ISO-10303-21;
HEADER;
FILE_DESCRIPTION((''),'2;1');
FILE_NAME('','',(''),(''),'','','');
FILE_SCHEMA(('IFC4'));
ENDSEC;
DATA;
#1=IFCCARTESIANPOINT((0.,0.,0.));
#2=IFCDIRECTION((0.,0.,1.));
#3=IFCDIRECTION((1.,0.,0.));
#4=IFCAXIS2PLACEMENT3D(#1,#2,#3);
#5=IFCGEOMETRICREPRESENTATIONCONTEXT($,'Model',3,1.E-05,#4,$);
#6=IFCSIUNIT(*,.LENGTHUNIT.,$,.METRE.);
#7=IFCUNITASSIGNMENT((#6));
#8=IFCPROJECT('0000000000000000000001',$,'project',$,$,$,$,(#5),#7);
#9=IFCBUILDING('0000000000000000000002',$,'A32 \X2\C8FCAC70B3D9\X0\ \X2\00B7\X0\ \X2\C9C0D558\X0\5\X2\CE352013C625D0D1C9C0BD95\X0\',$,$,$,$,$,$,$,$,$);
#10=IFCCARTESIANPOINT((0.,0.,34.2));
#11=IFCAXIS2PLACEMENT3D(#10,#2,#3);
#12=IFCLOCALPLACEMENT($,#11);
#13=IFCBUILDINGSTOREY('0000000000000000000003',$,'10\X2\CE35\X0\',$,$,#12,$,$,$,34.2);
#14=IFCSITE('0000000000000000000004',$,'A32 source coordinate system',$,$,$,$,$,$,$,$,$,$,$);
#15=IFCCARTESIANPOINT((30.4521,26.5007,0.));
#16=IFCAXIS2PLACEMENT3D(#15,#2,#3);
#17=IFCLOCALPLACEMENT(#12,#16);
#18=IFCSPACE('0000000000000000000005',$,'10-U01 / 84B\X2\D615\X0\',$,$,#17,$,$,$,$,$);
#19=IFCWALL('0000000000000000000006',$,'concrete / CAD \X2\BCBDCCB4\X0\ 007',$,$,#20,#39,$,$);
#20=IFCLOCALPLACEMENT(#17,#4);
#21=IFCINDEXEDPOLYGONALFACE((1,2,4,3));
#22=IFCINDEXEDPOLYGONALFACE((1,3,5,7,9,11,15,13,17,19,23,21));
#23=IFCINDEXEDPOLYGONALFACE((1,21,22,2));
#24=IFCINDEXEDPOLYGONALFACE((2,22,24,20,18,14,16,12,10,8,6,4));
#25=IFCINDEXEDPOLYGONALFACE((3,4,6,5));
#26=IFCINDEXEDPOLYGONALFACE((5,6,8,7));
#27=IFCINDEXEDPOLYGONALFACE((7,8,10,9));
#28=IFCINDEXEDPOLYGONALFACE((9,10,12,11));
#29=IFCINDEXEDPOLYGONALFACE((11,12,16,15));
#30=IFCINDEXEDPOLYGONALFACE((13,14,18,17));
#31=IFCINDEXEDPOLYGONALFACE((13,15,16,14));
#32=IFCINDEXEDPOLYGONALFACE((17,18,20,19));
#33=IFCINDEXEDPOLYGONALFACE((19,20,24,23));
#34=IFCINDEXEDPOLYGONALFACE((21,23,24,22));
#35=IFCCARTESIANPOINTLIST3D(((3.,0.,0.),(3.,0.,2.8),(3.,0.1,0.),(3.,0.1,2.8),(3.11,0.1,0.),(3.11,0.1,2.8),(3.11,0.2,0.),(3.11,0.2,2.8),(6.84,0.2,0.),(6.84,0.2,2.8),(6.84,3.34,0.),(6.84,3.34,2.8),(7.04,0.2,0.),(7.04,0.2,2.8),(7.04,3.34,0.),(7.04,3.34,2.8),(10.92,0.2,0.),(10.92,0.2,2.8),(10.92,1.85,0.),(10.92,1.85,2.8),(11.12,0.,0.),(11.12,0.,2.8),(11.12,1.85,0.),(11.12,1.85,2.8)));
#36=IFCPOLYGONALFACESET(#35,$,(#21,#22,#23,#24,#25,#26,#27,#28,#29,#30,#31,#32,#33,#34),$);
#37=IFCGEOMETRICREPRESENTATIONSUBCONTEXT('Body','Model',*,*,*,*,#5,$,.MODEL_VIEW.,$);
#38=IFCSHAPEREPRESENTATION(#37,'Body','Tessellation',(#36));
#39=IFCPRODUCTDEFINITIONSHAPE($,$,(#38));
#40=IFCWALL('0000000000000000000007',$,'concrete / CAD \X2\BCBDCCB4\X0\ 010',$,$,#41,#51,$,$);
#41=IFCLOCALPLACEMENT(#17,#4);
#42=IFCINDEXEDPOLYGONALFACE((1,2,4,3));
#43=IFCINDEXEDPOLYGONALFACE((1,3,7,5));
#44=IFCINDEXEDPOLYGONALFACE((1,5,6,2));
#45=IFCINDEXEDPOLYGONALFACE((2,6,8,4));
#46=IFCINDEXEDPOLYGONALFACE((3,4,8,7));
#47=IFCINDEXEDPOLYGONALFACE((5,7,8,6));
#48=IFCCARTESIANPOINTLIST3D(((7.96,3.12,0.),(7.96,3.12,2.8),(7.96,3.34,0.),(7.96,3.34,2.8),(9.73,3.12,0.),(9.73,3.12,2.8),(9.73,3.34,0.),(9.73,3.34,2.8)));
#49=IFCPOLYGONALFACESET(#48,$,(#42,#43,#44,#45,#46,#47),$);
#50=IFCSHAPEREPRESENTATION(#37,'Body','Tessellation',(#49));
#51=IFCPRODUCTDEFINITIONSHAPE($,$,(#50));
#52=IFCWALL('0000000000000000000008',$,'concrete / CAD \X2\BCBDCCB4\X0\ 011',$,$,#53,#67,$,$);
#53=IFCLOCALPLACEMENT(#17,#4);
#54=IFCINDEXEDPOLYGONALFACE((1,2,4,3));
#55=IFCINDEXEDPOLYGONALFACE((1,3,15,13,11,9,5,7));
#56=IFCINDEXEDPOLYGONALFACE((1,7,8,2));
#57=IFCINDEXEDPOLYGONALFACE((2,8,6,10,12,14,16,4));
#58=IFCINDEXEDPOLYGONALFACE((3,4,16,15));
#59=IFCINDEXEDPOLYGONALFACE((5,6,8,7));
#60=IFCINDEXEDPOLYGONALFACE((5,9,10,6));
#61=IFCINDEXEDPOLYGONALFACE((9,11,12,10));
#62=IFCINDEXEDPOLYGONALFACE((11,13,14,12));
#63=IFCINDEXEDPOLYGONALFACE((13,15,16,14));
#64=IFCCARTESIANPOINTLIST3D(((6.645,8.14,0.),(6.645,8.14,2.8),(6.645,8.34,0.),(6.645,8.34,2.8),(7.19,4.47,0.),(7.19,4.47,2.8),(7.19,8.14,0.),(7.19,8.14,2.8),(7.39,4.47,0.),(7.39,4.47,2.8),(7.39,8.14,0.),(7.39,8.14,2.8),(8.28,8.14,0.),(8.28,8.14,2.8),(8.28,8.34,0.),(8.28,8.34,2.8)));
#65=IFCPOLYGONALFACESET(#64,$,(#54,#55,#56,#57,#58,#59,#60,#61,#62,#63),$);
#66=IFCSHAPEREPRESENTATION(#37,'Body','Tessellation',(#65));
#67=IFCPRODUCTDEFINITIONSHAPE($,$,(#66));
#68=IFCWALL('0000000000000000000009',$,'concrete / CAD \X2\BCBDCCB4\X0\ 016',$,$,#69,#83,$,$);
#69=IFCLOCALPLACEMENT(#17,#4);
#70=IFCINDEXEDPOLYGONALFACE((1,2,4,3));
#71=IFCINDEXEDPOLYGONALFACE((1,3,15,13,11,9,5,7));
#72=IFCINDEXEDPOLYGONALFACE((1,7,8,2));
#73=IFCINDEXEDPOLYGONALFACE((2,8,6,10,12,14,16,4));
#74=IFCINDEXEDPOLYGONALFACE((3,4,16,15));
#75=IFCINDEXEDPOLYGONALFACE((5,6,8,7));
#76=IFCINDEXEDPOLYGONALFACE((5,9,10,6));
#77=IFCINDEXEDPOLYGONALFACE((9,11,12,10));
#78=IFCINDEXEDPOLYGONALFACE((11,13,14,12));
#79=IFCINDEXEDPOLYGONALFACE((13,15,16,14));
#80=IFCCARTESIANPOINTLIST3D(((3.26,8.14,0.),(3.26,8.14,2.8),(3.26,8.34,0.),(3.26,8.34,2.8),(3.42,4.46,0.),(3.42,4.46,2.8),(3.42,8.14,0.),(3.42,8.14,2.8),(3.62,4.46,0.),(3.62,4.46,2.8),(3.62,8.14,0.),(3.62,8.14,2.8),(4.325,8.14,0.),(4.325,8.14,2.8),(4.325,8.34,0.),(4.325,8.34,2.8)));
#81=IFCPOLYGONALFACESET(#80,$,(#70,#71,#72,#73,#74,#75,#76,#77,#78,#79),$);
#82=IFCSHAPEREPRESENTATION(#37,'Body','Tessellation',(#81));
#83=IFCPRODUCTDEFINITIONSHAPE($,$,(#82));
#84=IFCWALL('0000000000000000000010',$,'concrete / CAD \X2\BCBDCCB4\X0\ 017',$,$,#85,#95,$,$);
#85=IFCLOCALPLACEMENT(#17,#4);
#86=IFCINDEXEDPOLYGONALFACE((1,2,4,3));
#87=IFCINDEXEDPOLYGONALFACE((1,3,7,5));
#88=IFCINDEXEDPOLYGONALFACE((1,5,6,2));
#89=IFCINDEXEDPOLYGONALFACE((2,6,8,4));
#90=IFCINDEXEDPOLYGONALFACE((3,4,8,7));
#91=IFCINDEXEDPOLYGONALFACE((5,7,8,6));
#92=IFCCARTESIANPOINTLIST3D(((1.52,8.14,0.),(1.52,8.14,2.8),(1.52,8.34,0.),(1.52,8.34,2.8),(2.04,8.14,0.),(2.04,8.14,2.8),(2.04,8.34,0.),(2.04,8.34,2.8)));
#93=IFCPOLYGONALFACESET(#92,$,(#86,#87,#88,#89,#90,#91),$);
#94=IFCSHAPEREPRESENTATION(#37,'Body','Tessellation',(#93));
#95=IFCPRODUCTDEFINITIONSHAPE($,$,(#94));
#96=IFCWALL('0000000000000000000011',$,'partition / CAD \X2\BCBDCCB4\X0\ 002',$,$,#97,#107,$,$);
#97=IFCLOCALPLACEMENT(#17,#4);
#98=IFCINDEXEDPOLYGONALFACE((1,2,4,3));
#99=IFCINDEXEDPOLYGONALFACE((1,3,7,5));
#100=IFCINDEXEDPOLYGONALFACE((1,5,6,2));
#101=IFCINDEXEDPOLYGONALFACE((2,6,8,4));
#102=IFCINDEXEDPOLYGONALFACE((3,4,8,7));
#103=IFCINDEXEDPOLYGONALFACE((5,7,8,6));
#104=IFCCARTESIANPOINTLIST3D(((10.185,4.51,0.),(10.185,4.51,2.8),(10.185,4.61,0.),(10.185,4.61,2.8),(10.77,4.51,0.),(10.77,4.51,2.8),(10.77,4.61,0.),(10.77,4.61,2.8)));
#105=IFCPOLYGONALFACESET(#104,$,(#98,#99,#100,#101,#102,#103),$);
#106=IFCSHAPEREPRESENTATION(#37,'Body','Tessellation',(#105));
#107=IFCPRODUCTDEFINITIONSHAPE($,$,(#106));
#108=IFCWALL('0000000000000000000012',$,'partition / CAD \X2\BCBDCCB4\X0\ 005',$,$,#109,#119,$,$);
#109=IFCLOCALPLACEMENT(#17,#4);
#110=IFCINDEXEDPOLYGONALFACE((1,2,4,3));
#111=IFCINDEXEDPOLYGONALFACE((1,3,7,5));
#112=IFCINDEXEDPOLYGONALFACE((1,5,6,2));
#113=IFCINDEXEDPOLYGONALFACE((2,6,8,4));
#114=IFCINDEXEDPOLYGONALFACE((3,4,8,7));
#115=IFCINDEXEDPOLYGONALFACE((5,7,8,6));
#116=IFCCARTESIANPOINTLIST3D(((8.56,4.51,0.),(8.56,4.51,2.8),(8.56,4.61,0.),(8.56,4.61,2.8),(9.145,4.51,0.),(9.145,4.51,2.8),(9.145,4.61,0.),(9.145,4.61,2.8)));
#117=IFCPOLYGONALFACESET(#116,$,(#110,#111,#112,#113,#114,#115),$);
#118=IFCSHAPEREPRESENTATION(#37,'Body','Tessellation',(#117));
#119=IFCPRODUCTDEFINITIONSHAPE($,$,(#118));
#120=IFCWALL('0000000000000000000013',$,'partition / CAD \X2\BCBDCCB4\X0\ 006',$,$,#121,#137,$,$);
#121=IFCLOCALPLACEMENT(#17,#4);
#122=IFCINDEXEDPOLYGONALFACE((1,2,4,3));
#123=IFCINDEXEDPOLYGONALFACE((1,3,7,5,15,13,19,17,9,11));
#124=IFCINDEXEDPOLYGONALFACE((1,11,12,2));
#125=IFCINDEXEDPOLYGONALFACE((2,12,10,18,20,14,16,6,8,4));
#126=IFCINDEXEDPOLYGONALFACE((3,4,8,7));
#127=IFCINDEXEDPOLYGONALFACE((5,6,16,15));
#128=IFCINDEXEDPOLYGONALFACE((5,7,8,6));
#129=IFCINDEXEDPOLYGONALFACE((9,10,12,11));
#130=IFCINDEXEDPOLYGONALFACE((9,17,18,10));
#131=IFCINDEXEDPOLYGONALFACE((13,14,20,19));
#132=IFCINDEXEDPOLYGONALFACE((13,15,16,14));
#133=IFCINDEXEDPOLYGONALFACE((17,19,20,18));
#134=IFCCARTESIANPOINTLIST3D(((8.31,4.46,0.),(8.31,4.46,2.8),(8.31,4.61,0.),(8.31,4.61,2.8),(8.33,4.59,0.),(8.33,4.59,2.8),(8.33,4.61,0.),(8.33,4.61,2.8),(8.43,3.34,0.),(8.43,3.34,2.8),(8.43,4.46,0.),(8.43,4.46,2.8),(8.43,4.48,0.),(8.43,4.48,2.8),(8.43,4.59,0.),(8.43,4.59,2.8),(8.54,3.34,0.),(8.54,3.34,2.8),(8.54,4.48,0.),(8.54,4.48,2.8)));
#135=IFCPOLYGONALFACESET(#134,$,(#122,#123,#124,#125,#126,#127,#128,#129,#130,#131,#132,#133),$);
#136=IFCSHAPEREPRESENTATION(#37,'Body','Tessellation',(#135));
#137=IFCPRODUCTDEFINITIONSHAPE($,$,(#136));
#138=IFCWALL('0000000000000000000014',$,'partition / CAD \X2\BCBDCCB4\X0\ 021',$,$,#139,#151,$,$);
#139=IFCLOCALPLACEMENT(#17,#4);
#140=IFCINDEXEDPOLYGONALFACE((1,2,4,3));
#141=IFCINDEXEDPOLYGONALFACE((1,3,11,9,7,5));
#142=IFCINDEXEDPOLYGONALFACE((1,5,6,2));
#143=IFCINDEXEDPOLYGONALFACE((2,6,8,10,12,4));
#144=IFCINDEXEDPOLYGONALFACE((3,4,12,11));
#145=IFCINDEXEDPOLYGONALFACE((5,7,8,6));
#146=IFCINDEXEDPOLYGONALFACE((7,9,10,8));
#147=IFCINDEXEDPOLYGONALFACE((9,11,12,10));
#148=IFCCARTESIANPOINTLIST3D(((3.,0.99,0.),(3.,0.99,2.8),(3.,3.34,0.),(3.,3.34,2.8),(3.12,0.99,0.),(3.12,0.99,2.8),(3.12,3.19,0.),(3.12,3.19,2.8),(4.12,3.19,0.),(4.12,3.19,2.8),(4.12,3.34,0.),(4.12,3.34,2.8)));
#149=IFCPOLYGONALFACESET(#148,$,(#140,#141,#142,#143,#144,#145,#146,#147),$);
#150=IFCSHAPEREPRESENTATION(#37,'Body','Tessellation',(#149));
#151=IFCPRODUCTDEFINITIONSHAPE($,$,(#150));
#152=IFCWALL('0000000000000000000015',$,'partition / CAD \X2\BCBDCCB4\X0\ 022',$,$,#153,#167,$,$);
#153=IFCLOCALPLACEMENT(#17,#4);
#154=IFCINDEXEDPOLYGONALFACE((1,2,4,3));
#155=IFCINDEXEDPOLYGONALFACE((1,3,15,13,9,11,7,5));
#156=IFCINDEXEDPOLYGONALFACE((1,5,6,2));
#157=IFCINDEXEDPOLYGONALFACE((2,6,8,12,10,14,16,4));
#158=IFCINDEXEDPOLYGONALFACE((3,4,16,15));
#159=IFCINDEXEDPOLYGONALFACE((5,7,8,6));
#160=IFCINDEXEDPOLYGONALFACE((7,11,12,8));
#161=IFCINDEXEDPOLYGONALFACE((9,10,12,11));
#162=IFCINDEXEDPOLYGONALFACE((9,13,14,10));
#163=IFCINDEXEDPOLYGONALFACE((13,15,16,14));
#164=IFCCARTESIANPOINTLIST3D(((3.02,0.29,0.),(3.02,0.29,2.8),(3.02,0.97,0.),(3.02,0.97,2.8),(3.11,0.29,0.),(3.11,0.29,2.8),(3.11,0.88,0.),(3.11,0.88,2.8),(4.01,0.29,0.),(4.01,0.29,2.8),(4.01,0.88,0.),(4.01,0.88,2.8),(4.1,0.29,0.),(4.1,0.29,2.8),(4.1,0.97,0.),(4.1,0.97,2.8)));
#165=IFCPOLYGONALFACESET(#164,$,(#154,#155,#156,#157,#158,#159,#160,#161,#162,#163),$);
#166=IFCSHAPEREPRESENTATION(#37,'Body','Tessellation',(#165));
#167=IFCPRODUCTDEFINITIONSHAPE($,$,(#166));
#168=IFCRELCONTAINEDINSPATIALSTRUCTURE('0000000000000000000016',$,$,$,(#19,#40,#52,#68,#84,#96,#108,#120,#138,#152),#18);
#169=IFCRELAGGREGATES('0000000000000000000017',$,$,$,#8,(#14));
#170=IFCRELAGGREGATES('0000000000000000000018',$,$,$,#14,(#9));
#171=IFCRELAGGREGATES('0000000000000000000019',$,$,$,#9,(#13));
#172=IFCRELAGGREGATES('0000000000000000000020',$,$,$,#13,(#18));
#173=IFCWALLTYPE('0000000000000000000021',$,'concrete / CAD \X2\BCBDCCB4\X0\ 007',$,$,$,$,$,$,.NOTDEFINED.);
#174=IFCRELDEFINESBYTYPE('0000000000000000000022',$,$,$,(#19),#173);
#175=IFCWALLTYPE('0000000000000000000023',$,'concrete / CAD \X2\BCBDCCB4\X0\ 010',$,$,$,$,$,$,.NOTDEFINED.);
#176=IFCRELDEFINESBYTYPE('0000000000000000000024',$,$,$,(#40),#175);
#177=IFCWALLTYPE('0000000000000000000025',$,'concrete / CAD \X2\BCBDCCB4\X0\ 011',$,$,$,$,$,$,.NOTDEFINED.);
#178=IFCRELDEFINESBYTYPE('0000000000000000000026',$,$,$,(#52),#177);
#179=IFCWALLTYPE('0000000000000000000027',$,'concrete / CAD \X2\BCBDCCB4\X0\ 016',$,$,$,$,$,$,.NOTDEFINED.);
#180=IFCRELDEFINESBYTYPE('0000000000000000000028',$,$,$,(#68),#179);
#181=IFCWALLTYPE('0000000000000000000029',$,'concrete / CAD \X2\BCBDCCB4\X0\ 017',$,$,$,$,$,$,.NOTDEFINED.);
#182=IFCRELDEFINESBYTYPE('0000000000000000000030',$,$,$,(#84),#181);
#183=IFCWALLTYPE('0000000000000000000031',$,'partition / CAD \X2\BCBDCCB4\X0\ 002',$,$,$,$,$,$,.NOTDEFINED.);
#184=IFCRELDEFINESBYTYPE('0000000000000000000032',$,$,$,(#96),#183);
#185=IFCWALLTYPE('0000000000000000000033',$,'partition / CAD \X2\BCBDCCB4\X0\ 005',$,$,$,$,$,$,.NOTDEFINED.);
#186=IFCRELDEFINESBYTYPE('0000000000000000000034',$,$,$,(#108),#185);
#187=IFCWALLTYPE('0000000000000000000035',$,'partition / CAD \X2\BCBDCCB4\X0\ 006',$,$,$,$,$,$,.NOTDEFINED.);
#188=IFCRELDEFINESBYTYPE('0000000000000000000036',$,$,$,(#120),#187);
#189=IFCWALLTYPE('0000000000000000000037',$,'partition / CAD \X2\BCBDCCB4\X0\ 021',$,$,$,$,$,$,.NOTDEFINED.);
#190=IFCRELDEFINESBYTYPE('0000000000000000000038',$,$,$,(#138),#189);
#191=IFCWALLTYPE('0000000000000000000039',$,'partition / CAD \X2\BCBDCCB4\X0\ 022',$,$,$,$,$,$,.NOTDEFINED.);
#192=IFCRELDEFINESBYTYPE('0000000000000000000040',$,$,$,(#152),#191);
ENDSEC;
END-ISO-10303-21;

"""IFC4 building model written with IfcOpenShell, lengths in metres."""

from ifc_helpers import new_model, si_unit, frame, origin, origin_with_axes, place, context, subcontext, project, spatial, polyline, outline, extrude, source, transform, mapped, type_object, type_shapes, element, save


model = new_model("IFC4")

# Units and contexts
model_context = context("Model", 3, precision=1e-05, world=origin_with_axes())
body_context = subcontext(model_context, "Body", "Model", "MODEL_VIEW")
ifc_project = project(units=[si_unit("LENGTHUNIT", "METRE")], contexts=[model_context])

# Site, building, storey, space
site = spatial("IfcSite", under=ifc_project, Name="A32 source coordinate system")
building = spatial("IfcBuilding", under=site, Name="A32 주거동 · 지하5층–옥탑지붕")
storey_placement = place(None, frame((0.0, 0.0, 34.2), z_axis=(0.0, 0.0, 1.0), x_axis=(1.0, 0.0, 0.0)))
storey = spatial("IfcBuildingStorey", under=building, at=storey_placement, Name="10층", Elevation=34.2)
space_1_placement = place(storey_placement, frame((30.4521, 26.5007, 0.0), z_axis=(0.0, 0.0, 1.0), x_axis=(1.0, 0.0, 0.0)))
space_1 = spatial("IfcSpace", under=storey, at=space_1_placement, Name="10-U01 / 84B형")

# Walls
wall_type_1 = type_object("IfcWallType", Name="concrete / CAD 벽체 007", PredefinedType="NOTDEFINED")
shared_shape_1 = source(origin(), body_context, "Body", "SweptSolid", [
    extrude(outline(polyline([(3.0, 0.0), (3.0, 0.1), (3.11, 0.1), (3.11, 0.2), (6.84, 0.2), (6.84, 3.34), (7.04, 3.34), (7.04, 0.2), (10.92, 0.2), (10.92, 1.85), (11.12, 1.85), (11.12, 0.0), (3.0, 0.0)])), origin(), (0.0, 0.0, 1.0), 2.8),
])
type_shapes(wall_type_1, [shared_shape_1])
wall_1_placement = place(space_1_placement, origin_with_axes())
element("IfcWall", 1, at=wall_1_placement, inside=space_1, type_object=wall_type_1, Name="concrete / CAD 벽체 007", context=body_context, shape_type="MappedRepresentation", body=[
    mapped(shared_shape_1, transform((0.0, 0.0, 0.0), scale=1.0)),
])
wall_type_2 = type_object("IfcWallType", Name="concrete / CAD 벽체 010", PredefinedType="NOTDEFINED")
shared_shape_2 = source(origin(), body_context, "Body", "SweptSolid", [
    extrude(outline(polyline([(7.96, 3.12), (7.96, 3.34), (9.73, 3.34), (9.73, 3.12), (7.96, 3.12)])), origin(), (0.0, 0.0, 1.0), 2.8),
])
type_shapes(wall_type_2, [shared_shape_2])
wall_2_placement = place(space_1_placement, origin_with_axes())
element("IfcWall", 2, at=wall_2_placement, inside=space_1, type_object=wall_type_2, Name="concrete / CAD 벽체 010", context=body_context, shape_type="MappedRepresentation", body=[
    mapped(shared_shape_2, transform((0.0, 0.0, 0.0), scale=1.0)),
])
wall_type_3 = type_object("IfcWallType", Name="concrete / CAD 벽체 011", PredefinedType="NOTDEFINED")
shared_shape_3 = source(origin(), body_context, "Body", "SweptSolid", [
    extrude(outline(polyline([(7.19, 8.14), (6.645, 8.14), (6.645, 8.34), (8.28, 8.34), (8.28, 8.14), (7.39, 8.14), (7.39, 4.47), (7.19, 4.47), (7.19, 8.14)])), origin(), (0.0, 0.0, 1.0), 2.8),
])
type_shapes(wall_type_3, [shared_shape_3])
wall_3_placement = place(space_1_placement, origin_with_axes())
element("IfcWall", 3, at=wall_3_placement, inside=space_1, type_object=wall_type_3, Name="concrete / CAD 벽체 011", context=body_context, shape_type="MappedRepresentation", body=[
    mapped(shared_shape_3, transform((0.0, 0.0, 0.0), scale=1.0)),
])
wall_type_4 = type_object("IfcWallType", Name="concrete / CAD 벽체 016", PredefinedType="NOTDEFINED")
shared_shape_4 = source(origin(), body_context, "Body", "SweptSolid", [
    extrude(outline(polyline([(3.26, 8.14), (3.26, 8.34), (4.325, 8.34), (4.325, 8.14), (3.62, 8.14), (3.62, 4.46), (3.42, 4.46), (3.42, 8.14), (3.26, 8.14)])), origin(), (0.0, 0.0, 1.0), 2.8),
])
type_shapes(wall_type_4, [shared_shape_4])
wall_4_placement = place(space_1_placement, origin_with_axes())
element("IfcWall", 4, at=wall_4_placement, inside=space_1, type_object=wall_type_4, Name="concrete / CAD 벽체 016", context=body_context, shape_type="MappedRepresentation", body=[
    mapped(shared_shape_4, transform((0.0, 0.0, 0.0), scale=1.0)),
])
wall_type_5 = type_object("IfcWallType", Name="concrete / CAD 벽체 017", PredefinedType="NOTDEFINED")
shared_shape_5 = source(origin(), body_context, "Body", "SweptSolid", [
    extrude(outline(polyline([(1.52, 8.34), (2.04, 8.34), (2.04, 8.14), (1.52, 8.14), (1.52, 8.34)])), origin(), (0.0, 0.0, 1.0), 2.8),
])
type_shapes(wall_type_5, [shared_shape_5])
wall_5_placement = place(space_1_placement, origin_with_axes())
element("IfcWall", 5, at=wall_5_placement, inside=space_1, type_object=wall_type_5, Name="concrete / CAD 벽체 017", context=body_context, shape_type="MappedRepresentation", body=[
    mapped(shared_shape_5, transform((0.0, 0.0, 0.0), scale=1.0)),
])
wall_type_6 = type_object("IfcWallType", Name="partition / CAD 벽체 002", PredefinedType="NOTDEFINED")
shared_shape_6 = source(origin(), body_context, "Body", "SweptSolid", [
    extrude(outline(polyline([(10.185, 4.51), (10.185, 4.61), (10.77, 4.61), (10.77, 4.51), (10.185, 4.51)])), origin(), (0.0, 0.0, 1.0), 2.8),
])
type_shapes(wall_type_6, [shared_shape_6])
wall_6_placement = place(space_1_placement, origin_with_axes())
element("IfcWall", 6, at=wall_6_placement, inside=space_1, type_object=wall_type_6, Name="partition / CAD 벽체 002", context=body_context, shape_type="MappedRepresentation", body=[
    mapped(shared_shape_6, transform((0.0, 0.0, 0.0), scale=1.0)),
])
wall_type_7 = type_object("IfcWallType", Name="partition / CAD 벽체 005", PredefinedType="NOTDEFINED")
shared_shape_7 = source(origin(), body_context, "Body", "SweptSolid", [
    extrude(outline(polyline([(8.56, 4.51), (8.56, 4.61), (9.145, 4.61), (9.145, 4.51), (8.56, 4.51)])), origin(), (0.0, 0.0, 1.0), 2.8),
])
type_shapes(wall_type_7, [shared_shape_7])
wall_7_placement = place(space_1_placement, origin_with_axes())
element("IfcWall", 7, at=wall_7_placement, inside=space_1, type_object=wall_type_7, Name="partition / CAD 벽체 005", context=body_context, shape_type="MappedRepresentation", body=[
    mapped(shared_shape_7, transform((0.0, 0.0, 0.0), scale=1.0)),
])
wall_type_8 = type_object("IfcWallType", Name="partition / CAD 벽체 006", PredefinedType="NOTDEFINED")
shared_shape_8 = source(origin(), body_context, "Body", "SweptSolid", [
    extrude(outline(polyline([(8.43, 4.46), (8.31, 4.46), (8.31, 4.61), (8.33, 4.61), (8.33, 4.59), (8.43, 4.59), (8.43, 4.48), (8.54, 4.48), (8.54, 3.34), (8.43, 3.34), (8.43, 4.46)])), origin(), (0.0, 0.0, 1.0), 2.8),
])
type_shapes(wall_type_8, [shared_shape_8])
wall_8_placement = place(space_1_placement, origin_with_axes())
element("IfcWall", 8, at=wall_8_placement, inside=space_1, type_object=wall_type_8, Name="partition / CAD 벽체 006", context=body_context, shape_type="MappedRepresentation", body=[
    mapped(shared_shape_8, transform((0.0, 0.0, 0.0), scale=1.0)),
])
wall_type_9 = type_object("IfcWallType", Name="partition / CAD 벽체 021", PredefinedType="NOTDEFINED")
shared_shape_9 = source(origin(), body_context, "Body", "SweptSolid", [
    extrude(outline(polyline([(4.12, 3.34), (4.12, 3.19), (3.12, 3.19), (3.12, 0.99), (3.0, 0.99), (3.0, 3.34), (4.12, 3.34)])), origin(), (0.0, 0.0, 1.0), 2.8),
])
type_shapes(wall_type_9, [shared_shape_9])
wall_9_placement = place(space_1_placement, origin_with_axes())
element("IfcWall", 9, at=wall_9_placement, inside=space_1, type_object=wall_type_9, Name="partition / CAD 벽체 021", context=body_context, shape_type="MappedRepresentation", body=[
    mapped(shared_shape_9, transform((0.0, 0.0, 0.0), scale=1.0)),
])
wall_type_10 = type_object("IfcWallType", Name="partition / CAD 벽체 022", PredefinedType="NOTDEFINED")
shared_shape_10 = source(origin(), body_context, "Body", "SweptSolid", [
    extrude(outline(polyline([(4.1, 0.97), (4.1, 0.29), (4.01, 0.29), (4.01, 0.88), (3.11, 0.88), (3.11, 0.29), (3.02, 0.29), (3.02, 0.97), (4.1, 0.97)])), origin(), (0.0, 0.0, 1.0), 2.8),
])
type_shapes(wall_type_10, [shared_shape_10])
wall_10_placement = place(space_1_placement, origin_with_axes())
element("IfcWall", 10, at=wall_10_placement, inside=space_1, type_object=wall_type_10, Name="partition / CAD 벽체 022", context=body_context, shape_type="MappedRepresentation", body=[
    mapped(shared_shape_10, transform((0.0, 0.0, 0.0), scale=1.0)),
])

save(model, "model.ifc")
